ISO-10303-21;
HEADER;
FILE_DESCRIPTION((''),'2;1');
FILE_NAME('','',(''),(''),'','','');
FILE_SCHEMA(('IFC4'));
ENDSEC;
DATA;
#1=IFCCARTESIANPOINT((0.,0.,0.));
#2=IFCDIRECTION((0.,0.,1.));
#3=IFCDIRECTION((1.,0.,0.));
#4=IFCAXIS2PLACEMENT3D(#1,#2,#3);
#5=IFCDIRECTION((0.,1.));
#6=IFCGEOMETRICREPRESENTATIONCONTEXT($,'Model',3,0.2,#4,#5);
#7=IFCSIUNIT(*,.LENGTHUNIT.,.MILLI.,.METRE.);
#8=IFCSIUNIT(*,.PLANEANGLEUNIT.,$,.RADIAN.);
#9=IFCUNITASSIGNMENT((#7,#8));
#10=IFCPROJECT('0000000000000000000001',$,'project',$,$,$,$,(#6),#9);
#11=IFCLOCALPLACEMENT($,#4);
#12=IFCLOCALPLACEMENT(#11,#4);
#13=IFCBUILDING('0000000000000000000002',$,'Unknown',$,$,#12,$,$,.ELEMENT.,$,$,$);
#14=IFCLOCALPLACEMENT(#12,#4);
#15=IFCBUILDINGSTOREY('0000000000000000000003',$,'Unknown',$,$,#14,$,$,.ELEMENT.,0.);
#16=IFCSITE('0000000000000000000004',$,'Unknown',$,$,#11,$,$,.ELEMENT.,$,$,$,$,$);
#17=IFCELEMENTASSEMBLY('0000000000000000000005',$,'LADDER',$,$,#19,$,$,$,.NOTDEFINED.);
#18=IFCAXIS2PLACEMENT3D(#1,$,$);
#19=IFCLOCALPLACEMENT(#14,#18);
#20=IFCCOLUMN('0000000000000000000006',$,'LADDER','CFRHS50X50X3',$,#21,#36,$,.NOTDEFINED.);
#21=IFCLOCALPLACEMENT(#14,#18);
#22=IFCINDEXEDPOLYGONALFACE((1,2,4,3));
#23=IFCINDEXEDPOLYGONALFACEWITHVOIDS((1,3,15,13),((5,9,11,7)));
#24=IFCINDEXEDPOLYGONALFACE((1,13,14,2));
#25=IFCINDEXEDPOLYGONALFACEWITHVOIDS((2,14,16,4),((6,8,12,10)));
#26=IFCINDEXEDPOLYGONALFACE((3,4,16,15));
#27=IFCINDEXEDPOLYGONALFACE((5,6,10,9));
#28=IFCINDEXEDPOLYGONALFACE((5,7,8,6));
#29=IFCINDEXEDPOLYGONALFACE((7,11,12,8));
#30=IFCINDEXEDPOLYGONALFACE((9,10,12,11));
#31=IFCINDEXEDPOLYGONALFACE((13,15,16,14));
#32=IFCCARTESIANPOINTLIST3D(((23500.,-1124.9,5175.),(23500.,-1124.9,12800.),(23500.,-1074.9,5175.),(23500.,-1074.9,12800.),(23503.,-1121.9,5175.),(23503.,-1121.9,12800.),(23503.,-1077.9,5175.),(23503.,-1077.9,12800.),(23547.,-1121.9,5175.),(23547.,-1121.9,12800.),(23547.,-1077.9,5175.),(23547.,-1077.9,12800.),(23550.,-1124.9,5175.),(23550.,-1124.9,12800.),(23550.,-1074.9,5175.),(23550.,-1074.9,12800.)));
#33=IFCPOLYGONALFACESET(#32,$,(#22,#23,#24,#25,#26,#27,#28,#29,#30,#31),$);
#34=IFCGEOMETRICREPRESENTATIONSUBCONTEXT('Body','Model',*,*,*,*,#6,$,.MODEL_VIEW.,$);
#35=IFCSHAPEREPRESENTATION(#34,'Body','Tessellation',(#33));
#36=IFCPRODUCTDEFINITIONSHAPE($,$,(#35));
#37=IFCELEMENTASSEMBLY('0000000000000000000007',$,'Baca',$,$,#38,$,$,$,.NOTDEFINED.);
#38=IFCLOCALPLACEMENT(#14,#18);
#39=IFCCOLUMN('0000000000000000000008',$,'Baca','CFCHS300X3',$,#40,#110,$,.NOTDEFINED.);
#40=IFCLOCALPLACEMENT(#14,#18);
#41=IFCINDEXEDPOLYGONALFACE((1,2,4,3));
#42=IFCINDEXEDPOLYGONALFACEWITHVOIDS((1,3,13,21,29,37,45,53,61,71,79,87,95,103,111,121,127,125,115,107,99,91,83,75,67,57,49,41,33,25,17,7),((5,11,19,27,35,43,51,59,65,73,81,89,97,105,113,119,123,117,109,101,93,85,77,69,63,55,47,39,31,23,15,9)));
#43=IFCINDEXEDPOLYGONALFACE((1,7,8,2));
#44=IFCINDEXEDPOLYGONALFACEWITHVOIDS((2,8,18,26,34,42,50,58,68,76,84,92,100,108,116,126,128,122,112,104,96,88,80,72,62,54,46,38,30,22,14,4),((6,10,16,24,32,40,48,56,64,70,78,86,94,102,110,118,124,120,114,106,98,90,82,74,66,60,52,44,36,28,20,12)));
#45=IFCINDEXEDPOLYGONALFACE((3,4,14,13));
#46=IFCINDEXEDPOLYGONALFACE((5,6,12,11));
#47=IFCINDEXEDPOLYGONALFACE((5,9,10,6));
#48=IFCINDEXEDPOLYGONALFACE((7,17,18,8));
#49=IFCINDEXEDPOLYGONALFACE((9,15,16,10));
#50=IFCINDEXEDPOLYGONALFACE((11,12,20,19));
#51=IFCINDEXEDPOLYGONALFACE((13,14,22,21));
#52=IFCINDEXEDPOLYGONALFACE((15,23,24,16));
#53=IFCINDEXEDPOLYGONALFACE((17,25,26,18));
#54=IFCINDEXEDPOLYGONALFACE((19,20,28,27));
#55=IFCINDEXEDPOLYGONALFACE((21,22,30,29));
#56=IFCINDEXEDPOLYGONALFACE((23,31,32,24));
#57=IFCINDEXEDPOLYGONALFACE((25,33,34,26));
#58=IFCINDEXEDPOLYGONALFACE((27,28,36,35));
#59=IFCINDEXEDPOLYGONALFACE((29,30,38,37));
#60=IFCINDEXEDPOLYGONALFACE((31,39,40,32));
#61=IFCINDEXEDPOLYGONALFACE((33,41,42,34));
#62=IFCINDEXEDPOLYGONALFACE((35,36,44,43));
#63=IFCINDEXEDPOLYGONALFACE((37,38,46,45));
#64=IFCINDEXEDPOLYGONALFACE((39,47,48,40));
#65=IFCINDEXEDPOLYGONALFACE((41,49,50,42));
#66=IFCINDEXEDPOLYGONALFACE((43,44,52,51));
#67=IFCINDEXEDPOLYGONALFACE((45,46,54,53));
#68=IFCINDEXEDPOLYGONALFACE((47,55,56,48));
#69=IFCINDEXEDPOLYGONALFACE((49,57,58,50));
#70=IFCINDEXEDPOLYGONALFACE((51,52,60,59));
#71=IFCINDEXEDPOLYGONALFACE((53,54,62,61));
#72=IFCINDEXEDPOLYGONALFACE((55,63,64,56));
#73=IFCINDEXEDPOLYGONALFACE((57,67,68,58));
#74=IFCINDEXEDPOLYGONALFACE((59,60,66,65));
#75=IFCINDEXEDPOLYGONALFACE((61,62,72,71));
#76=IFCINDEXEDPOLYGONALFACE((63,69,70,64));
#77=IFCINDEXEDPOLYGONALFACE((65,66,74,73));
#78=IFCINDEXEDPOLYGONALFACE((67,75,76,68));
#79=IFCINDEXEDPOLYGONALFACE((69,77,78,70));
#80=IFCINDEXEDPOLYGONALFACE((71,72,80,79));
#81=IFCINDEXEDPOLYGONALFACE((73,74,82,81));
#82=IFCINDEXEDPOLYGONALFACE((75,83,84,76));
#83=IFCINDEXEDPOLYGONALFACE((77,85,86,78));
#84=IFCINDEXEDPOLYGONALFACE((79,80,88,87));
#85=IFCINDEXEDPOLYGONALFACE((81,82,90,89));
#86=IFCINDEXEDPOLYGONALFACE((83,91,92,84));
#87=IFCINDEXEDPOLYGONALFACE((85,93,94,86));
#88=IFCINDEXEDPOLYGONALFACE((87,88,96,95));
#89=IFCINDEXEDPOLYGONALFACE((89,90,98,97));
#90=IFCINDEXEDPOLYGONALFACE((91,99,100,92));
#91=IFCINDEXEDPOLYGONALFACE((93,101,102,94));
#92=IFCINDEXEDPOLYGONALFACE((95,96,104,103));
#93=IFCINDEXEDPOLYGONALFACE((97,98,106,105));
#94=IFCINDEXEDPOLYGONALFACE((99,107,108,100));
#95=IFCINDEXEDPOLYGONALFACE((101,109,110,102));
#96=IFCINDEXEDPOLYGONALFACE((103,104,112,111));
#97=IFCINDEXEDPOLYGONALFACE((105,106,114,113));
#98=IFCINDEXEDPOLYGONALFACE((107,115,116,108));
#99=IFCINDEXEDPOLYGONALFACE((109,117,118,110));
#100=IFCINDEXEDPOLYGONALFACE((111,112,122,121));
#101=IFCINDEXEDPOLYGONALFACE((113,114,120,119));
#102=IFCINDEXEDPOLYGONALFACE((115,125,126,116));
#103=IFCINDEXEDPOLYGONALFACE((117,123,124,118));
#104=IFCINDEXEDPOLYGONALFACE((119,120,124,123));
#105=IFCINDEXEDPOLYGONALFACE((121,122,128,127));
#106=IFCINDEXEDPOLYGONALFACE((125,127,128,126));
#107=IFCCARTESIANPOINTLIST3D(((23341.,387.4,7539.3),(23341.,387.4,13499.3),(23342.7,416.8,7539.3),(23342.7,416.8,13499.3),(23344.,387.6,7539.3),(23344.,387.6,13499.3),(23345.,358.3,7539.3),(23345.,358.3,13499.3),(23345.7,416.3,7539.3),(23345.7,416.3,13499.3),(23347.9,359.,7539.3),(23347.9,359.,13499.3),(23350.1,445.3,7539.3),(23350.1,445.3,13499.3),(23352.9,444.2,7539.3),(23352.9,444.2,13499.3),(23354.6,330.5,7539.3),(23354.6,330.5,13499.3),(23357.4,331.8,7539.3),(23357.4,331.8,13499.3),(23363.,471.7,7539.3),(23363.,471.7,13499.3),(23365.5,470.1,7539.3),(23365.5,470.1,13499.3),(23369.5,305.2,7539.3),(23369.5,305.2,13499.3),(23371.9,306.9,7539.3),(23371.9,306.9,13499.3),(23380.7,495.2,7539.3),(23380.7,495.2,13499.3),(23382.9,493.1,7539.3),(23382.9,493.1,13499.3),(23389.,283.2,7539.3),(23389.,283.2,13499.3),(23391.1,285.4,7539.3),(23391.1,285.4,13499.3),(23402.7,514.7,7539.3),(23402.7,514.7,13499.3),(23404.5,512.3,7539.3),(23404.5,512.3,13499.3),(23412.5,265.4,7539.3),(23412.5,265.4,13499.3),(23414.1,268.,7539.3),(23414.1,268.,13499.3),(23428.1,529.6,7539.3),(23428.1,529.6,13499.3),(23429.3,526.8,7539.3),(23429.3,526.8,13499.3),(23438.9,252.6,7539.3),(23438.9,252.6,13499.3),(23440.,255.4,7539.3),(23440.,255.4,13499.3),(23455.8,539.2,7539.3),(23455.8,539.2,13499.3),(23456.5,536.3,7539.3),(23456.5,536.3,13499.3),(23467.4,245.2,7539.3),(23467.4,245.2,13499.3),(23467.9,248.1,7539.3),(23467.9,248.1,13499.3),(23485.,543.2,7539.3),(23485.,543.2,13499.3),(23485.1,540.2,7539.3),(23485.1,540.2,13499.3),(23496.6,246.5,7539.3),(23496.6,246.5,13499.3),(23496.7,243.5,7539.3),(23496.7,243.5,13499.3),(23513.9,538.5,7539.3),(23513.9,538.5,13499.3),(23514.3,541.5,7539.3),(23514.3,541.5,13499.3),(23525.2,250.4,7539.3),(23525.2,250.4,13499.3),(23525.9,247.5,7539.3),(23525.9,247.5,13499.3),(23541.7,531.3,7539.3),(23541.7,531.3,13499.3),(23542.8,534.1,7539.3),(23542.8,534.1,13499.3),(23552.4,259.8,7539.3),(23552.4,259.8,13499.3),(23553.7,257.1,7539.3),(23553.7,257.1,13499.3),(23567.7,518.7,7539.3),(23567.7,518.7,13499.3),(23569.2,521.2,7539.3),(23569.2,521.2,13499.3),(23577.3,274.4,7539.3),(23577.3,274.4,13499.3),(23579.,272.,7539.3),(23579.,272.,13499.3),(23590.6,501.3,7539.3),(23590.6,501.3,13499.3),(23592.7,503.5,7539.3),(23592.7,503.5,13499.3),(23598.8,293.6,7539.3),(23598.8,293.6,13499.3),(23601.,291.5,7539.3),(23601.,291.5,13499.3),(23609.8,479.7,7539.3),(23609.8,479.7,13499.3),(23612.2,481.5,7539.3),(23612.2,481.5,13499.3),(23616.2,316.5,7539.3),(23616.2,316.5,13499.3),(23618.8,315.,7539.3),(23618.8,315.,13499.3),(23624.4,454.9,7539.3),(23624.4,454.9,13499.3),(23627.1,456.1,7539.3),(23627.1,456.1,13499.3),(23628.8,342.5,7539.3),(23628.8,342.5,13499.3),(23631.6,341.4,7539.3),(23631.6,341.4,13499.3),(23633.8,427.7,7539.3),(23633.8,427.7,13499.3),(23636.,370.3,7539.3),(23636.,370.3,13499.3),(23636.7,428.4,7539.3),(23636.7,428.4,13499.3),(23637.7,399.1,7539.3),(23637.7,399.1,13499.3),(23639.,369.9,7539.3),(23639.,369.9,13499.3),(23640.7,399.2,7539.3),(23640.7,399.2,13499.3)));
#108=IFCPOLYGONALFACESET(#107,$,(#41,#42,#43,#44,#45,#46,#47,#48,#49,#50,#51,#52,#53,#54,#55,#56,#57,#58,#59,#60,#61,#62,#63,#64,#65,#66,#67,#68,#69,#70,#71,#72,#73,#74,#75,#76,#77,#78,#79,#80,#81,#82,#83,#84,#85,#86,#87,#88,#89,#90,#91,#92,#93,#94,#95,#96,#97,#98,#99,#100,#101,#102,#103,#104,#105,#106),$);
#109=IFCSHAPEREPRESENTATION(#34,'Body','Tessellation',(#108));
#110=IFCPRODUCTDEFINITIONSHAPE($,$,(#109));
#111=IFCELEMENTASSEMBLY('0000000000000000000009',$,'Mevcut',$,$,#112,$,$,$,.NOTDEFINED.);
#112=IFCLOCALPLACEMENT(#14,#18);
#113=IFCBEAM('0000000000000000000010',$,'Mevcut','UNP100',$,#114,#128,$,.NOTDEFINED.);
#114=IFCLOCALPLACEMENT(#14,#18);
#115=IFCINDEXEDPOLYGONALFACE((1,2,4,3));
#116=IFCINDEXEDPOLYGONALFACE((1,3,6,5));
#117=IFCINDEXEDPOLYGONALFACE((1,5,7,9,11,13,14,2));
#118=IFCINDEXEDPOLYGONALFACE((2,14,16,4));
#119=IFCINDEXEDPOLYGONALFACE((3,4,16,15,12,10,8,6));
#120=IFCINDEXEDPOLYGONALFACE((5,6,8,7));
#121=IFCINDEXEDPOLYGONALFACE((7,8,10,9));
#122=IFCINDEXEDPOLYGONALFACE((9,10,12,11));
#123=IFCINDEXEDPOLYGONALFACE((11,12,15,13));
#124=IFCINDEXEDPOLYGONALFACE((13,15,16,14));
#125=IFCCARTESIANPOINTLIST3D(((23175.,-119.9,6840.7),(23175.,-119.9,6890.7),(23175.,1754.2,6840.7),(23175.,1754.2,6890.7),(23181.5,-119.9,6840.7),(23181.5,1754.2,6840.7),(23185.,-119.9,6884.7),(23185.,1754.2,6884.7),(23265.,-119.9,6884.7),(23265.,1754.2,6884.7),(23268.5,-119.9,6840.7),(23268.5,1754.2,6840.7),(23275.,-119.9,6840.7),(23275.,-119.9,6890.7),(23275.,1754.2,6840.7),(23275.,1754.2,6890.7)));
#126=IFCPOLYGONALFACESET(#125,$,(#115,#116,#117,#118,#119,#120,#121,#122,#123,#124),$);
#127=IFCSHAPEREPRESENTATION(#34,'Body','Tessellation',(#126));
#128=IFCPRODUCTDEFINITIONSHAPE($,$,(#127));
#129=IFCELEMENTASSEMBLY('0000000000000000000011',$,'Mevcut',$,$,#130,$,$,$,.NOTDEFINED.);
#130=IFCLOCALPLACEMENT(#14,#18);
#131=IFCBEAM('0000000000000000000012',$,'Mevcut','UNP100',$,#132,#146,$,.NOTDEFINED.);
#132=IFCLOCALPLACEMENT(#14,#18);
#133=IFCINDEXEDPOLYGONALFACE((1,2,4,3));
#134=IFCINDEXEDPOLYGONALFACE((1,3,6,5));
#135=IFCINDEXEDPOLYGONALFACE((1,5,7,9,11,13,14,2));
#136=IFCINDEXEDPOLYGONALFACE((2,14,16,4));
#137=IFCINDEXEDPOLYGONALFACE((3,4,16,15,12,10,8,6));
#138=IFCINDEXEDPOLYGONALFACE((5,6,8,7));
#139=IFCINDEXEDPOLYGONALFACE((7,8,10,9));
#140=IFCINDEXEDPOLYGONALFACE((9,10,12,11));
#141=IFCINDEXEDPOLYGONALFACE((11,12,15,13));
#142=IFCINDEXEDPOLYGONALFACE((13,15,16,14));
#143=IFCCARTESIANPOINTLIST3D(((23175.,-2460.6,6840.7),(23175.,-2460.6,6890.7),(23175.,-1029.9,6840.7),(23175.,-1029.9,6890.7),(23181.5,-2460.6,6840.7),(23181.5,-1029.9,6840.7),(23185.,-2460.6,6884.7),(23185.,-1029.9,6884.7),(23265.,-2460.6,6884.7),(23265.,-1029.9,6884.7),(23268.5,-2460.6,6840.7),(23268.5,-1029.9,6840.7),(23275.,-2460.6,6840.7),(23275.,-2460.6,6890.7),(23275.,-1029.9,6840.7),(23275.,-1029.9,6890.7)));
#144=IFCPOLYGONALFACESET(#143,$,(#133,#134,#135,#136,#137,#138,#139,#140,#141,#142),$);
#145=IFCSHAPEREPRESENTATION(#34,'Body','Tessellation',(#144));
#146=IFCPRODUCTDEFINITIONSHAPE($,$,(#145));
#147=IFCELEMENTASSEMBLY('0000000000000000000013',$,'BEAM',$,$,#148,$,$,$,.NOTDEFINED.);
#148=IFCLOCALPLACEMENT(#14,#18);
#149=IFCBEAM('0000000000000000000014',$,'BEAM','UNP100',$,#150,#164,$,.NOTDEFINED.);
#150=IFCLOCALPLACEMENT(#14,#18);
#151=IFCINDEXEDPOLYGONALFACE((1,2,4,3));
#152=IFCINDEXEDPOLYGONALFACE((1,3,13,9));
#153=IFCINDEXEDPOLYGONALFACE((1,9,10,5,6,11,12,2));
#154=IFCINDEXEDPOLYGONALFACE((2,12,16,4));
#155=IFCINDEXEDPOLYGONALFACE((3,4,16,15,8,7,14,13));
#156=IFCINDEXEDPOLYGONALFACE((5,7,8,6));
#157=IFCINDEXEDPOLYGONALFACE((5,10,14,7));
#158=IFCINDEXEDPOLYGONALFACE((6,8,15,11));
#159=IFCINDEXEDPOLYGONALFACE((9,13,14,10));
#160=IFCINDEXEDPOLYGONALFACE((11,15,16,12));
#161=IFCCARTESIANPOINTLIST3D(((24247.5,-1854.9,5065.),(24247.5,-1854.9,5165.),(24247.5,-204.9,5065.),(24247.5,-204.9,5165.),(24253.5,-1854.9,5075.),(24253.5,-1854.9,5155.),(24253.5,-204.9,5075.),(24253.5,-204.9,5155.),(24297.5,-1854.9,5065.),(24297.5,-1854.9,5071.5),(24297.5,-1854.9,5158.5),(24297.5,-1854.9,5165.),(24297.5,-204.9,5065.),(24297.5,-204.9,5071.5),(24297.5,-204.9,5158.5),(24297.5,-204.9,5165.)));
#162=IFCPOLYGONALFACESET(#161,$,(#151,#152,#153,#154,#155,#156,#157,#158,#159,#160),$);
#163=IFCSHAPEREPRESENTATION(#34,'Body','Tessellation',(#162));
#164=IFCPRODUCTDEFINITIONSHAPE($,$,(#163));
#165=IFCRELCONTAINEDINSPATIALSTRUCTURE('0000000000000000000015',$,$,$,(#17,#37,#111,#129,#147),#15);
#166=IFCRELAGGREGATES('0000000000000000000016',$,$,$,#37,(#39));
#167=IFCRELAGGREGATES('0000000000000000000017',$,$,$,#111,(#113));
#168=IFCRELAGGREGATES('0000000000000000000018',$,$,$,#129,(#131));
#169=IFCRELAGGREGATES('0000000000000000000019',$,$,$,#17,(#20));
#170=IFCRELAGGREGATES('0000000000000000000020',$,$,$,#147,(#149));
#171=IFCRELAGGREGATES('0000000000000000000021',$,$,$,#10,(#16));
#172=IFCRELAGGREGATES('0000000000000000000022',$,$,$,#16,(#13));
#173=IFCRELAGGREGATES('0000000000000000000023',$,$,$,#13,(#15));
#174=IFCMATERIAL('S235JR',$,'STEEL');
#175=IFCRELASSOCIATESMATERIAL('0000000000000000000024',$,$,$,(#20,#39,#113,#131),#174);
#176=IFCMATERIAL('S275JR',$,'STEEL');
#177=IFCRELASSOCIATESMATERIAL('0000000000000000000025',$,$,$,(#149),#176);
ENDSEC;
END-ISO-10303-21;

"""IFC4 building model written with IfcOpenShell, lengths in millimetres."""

from ifc_helpers import new_model, si_unit, direction, frame, origin_with_axes, place, context, subcontext, project, spatial, line, indexed_curve, outline, extrude, material, element, aggregate, save


model = new_model("IFC4")

# Units and contexts
model_context = context("Model", 3, precision=0.2, world=origin_with_axes(), true_north=direction((0.0, 1.0)))
body_context = subcontext(model_context, "Body", "Model", "MODEL_VIEW")
ifc_project = project(units=[si_unit("LENGTHUNIT", "METRE", prefix="MILLI"), si_unit("PLANEANGLEUNIT", "RADIAN")], contexts=[model_context])

# Site, building, storey
site_placement = place(None, origin_with_axes())
site = spatial("IfcSite", under=ifc_project, at=site_placement, Name="Unknown", CompositionType="ELEMENT")
building_placement = place(site_placement, origin_with_axes())
building = spatial("IfcBuilding", under=site, at=building_placement, Name="Unknown", CompositionType="ELEMENT")
storey_placement = place(building_placement, origin_with_axes())
storey = spatial("IfcBuildingStorey", under=building, at=storey_placement, Name="Unknown", CompositionType="ELEMENT", Elevation=0.0)

# Element assemblies, columns
assembly_1_placement = place(storey_placement, frame((23525.0, -1699.9, 5175.0), z_axis=(0.0, 1.0, 0.0), x_axis=(0.0, 0.0, 1.0)))
assembly_1 = element("IfcElementAssembly", 1, at=assembly_1_placement, inside=storey, Name="LADDER", PredefinedType="NOTDEFINED")
ifc_material_1 = material(Name="S235JR", Category="STEEL")
column_1_placement = place(assembly_1_placement, frame((0.0, 0.0, 600.0), z_axis=(0.0, 0.0, 1.0), x_axis=(1.0, 0.0, 0.0)))
column_1 = element("IfcColumn", 2, at=column_1_placement, material=ifc_material_1, Name="LADDER", Description="CFRHS50X50X3", PredefinedType="NOTDEFINED", context=body_context, shape_type="SolidModel", body=[
    extrude(outline(indexed_curve([(-25.0, -25.0), (25.0, -25.0), (25.0, 25.0), (-25.0, 25.0)], segments=[line(1, 2, 3, 4, 1)]), holes=[indexed_curve([(-22.0, -22.0), (-22.0, 22.0), (22.0, 22.0), (22.0, -22.0)], segments=[line(1, 2, 3, 4, 1)])]), frame((0.0, 0.0, 0.0), z_axis=(-1.0, 0.0, 0.0), x_axis=(0.0, 0.0, 1.0)), (0.0, 0.0, -1.0), 7625.0),
])
assembly_2_placement = place(storey_placement, frame((23490.9, 393.3, 7539.3), z_axis=(0.987688, -0.156434, 0.0), x_axis=(0.0, 0.0, 1.0)))
assembly_2 = element("IfcElementAssembly", 3, at=assembly_2_placement, inside=storey, Name="Baca", PredefinedType="NOTDEFINED")
column_2_placement = place(assembly_2_placement, origin_with_axes())
column_2 = element("IfcColumn", 4, at=column_2_placement, material=ifc_material_1, Name="Baca", Description="CFCHS300X3", PredefinedType="NOTDEFINED", context=body_context, shape_type="SolidModel", body=[
    extrude(outline(indexed_curve([(150.0, 0.0), (147.1, 29.3), (138.6, 57.4), (124.7, 83.3), (106.1, 106.1), (83.3, 124.7), (57.4, 138.6), (29.3, 147.1), (0.0, 150.0), (-29.3, 147.1), (-57.4, 138.6), (-83.3, 124.7), (-106.1, 106.1), (-124.7, 83.3), (-138.6, 57.4), (-147.1, 29.3), (-150.0, 0.0), (-147.1, -29.3), (-138.6, -57.4), (-124.7, -83.3), (-106.1, -106.1), (-83.3, -124.7), (-57.4, -138.6), (-29.3, -147.1), (0.0, -150.0), (29.3, -147.1), (57.4, -138.6), (83.3, -124.7), (106.1, -106.1), (124.7, -83.3), (138.6, -57.4), (147.1, -29.3)], segments=[line(1, 2, 3, 4, 5, 6, 7, 8, 9, 10, 11, 12, 13, 14, 15, 16, 17, 18, 19, 20, 21, 22, 23, 24, 25, 26, 27, 28, 29, 30, 31, 32, 1)]), holes=[indexed_curve([(147.0, 0.0), (144.2, -28.7), (135.8, -56.3), (122.2, -81.7), (103.9, -103.9), (81.7, -122.2), (56.3, -135.8), (28.7, -144.2), (0.0, -147.0), (-28.7, -144.2), (-56.3, -135.8), (-81.7, -122.2), (-103.9, -103.9), (-122.2, -81.7), (-135.8, -56.3), (-144.2, -28.7), (-147.0, 0.0), (-144.2, 28.7), (-135.8, 56.3), (-122.2, 81.7), (-103.9, 103.9), (-81.7, 122.2), (-56.3, 135.8), (-28.7, 144.2), (0.0, 147.0), (28.7, 144.2), (56.3, 135.8), (81.7, 122.2), (103.9, 103.9), (122.2, 81.7), (135.8, 56.3), (144.2, 28.7)], segments=[line(1, 2, 3, 4, 5, 6, 7, 8, 9, 10, 11, 12, 13, 14, 15, 16, 17, 18, 19, 20, 21, 22, 23, 24, 25, 26, 27, 28, 29, 30, 31, 32, 1)])]), frame((0.0, 0.0, 0.0), z_axis=(-1.0, 0.0, 0.0), x_axis=(0.0, 0.0, 1.0)), (0.0, 0.0, -1.0), 5960.0),
])
aggregate(assembly_2, [column_2])

# Shared definitions
ifc_material_2 = material(Name="S275JR", Category="STEEL")

# Element assemblies, beams
assembly_3_placement = place(storey_placement, frame((23225.0, 1754.2, 6865.7), z_axis=(0.0, 0.0, -1.0), x_axis=(0.0, -1.0, 0.0)))
assembly_3 = element("IfcElementAssembly", 5, at=assembly_3_placement, inside=storey, Name="Mevcut", PredefinedType="NOTDEFINED")
beam_1_placement = place(assembly_3_placement, origin_with_axes())
beam_1 = element("IfcBeam", 6, at=beam_1_placement, material=ifc_material_1, Name="Mevcut", Description="UNP100", PredefinedType="NOTDEFINED", context=body_context, shape_type="SolidModel", body=[
    extrude(outline(indexed_curve([(-25.0, -50.0), (25.0, -50.0), (25.0, -43.5), (-19.0, -40.0), (-19.0, 40.0), (25.0, 43.5), (25.0, 50.0), (-25.0, 50.0)], segments=[line(1, 2, 3, 4, 5, 6, 7, 8, 1)])), frame((0.0, 0.0, 0.0), z_axis=(-1.0, 0.0, 0.0), x_axis=(0.0, 0.0, 1.0)), (0.0, 0.0, -1.0), 1874.2),
])
aggregate(assembly_3, [beam_1])
assembly_4_placement = place(storey_placement, frame((23225.0, -1029.9, 6865.7), z_axis=(0.0, 0.0, -1.0), x_axis=(0.0, -1.0, 0.0)))
assembly_4 = element("IfcElementAssembly", 7, at=assembly_4_placement, inside=storey, Name="Mevcut", PredefinedType="NOTDEFINED")
beam_2_placement = place(assembly_4_placement, origin_with_axes())
beam_2 = element("IfcBeam", 8, at=beam_2_placement, material=ifc_material_1, Name="Mevcut", Description="UNP100", PredefinedType="NOTDEFINED", context=body_context, shape_type="SolidModel", body=[
    extrude(outline(indexed_curve([(-25.0, -50.0), (25.0, -50.0), (25.0, -43.5), (-19.0, -40.0), (-19.0, 40.0), (25.0, 43.5), (25.0, 50.0), (-25.0, 50.0)], segments=[line(1, 2, 3, 4, 5, 6, 7, 8, 1)])), frame((0.0, 0.0, 0.0), z_axis=(-1.0, 0.0, 0.0), x_axis=(0.0, 0.0, 1.0)), (0.0, 0.0, -1.0), 1430.7),
])
aggregate(assembly_4, [beam_2])
assembly_5_placement = place(storey_placement, frame((24272.5, -204.9, 5115.0), z_axis=(1.0, 0.0, 0.0), x_axis=(0.0, -1.0, 0.0)))
assembly_5 = element("IfcElementAssembly", 9, at=assembly_5_placement, inside=storey, Name="BEAM", PredefinedType="NOTDEFINED")
beam_3_placement = place(assembly_5_placement, origin_with_axes())
beam_3 = element("IfcBeam", 10, at=beam_3_placement, material=ifc_material_2, Name="BEAM", Description="UNP100", PredefinedType="NOTDEFINED", context=body_context, shape_type="SolidModel", body=[
    extrude(outline(indexed_curve([(-25.0, -50.0), (25.0, -50.0), (25.0, -43.5), (-19.0, -40.0), (-19.0, 40.0), (25.0, 43.5), (25.0, 50.0), (-25.0, 50.0)], segments=[line(1, 2, 3, 4, 5, 6, 7, 8, 1)])), frame((0.0, 0.0, 0.0), z_axis=(-1.0, 0.0, 0.0), x_axis=(0.0, 0.0, 1.0)), (0.0, 0.0, -1.0), 1650.0),
])

aggregate(assembly_1, [column_1])

aggregate(assembly_5, [beam_3])

save(model, "model.ifc")
